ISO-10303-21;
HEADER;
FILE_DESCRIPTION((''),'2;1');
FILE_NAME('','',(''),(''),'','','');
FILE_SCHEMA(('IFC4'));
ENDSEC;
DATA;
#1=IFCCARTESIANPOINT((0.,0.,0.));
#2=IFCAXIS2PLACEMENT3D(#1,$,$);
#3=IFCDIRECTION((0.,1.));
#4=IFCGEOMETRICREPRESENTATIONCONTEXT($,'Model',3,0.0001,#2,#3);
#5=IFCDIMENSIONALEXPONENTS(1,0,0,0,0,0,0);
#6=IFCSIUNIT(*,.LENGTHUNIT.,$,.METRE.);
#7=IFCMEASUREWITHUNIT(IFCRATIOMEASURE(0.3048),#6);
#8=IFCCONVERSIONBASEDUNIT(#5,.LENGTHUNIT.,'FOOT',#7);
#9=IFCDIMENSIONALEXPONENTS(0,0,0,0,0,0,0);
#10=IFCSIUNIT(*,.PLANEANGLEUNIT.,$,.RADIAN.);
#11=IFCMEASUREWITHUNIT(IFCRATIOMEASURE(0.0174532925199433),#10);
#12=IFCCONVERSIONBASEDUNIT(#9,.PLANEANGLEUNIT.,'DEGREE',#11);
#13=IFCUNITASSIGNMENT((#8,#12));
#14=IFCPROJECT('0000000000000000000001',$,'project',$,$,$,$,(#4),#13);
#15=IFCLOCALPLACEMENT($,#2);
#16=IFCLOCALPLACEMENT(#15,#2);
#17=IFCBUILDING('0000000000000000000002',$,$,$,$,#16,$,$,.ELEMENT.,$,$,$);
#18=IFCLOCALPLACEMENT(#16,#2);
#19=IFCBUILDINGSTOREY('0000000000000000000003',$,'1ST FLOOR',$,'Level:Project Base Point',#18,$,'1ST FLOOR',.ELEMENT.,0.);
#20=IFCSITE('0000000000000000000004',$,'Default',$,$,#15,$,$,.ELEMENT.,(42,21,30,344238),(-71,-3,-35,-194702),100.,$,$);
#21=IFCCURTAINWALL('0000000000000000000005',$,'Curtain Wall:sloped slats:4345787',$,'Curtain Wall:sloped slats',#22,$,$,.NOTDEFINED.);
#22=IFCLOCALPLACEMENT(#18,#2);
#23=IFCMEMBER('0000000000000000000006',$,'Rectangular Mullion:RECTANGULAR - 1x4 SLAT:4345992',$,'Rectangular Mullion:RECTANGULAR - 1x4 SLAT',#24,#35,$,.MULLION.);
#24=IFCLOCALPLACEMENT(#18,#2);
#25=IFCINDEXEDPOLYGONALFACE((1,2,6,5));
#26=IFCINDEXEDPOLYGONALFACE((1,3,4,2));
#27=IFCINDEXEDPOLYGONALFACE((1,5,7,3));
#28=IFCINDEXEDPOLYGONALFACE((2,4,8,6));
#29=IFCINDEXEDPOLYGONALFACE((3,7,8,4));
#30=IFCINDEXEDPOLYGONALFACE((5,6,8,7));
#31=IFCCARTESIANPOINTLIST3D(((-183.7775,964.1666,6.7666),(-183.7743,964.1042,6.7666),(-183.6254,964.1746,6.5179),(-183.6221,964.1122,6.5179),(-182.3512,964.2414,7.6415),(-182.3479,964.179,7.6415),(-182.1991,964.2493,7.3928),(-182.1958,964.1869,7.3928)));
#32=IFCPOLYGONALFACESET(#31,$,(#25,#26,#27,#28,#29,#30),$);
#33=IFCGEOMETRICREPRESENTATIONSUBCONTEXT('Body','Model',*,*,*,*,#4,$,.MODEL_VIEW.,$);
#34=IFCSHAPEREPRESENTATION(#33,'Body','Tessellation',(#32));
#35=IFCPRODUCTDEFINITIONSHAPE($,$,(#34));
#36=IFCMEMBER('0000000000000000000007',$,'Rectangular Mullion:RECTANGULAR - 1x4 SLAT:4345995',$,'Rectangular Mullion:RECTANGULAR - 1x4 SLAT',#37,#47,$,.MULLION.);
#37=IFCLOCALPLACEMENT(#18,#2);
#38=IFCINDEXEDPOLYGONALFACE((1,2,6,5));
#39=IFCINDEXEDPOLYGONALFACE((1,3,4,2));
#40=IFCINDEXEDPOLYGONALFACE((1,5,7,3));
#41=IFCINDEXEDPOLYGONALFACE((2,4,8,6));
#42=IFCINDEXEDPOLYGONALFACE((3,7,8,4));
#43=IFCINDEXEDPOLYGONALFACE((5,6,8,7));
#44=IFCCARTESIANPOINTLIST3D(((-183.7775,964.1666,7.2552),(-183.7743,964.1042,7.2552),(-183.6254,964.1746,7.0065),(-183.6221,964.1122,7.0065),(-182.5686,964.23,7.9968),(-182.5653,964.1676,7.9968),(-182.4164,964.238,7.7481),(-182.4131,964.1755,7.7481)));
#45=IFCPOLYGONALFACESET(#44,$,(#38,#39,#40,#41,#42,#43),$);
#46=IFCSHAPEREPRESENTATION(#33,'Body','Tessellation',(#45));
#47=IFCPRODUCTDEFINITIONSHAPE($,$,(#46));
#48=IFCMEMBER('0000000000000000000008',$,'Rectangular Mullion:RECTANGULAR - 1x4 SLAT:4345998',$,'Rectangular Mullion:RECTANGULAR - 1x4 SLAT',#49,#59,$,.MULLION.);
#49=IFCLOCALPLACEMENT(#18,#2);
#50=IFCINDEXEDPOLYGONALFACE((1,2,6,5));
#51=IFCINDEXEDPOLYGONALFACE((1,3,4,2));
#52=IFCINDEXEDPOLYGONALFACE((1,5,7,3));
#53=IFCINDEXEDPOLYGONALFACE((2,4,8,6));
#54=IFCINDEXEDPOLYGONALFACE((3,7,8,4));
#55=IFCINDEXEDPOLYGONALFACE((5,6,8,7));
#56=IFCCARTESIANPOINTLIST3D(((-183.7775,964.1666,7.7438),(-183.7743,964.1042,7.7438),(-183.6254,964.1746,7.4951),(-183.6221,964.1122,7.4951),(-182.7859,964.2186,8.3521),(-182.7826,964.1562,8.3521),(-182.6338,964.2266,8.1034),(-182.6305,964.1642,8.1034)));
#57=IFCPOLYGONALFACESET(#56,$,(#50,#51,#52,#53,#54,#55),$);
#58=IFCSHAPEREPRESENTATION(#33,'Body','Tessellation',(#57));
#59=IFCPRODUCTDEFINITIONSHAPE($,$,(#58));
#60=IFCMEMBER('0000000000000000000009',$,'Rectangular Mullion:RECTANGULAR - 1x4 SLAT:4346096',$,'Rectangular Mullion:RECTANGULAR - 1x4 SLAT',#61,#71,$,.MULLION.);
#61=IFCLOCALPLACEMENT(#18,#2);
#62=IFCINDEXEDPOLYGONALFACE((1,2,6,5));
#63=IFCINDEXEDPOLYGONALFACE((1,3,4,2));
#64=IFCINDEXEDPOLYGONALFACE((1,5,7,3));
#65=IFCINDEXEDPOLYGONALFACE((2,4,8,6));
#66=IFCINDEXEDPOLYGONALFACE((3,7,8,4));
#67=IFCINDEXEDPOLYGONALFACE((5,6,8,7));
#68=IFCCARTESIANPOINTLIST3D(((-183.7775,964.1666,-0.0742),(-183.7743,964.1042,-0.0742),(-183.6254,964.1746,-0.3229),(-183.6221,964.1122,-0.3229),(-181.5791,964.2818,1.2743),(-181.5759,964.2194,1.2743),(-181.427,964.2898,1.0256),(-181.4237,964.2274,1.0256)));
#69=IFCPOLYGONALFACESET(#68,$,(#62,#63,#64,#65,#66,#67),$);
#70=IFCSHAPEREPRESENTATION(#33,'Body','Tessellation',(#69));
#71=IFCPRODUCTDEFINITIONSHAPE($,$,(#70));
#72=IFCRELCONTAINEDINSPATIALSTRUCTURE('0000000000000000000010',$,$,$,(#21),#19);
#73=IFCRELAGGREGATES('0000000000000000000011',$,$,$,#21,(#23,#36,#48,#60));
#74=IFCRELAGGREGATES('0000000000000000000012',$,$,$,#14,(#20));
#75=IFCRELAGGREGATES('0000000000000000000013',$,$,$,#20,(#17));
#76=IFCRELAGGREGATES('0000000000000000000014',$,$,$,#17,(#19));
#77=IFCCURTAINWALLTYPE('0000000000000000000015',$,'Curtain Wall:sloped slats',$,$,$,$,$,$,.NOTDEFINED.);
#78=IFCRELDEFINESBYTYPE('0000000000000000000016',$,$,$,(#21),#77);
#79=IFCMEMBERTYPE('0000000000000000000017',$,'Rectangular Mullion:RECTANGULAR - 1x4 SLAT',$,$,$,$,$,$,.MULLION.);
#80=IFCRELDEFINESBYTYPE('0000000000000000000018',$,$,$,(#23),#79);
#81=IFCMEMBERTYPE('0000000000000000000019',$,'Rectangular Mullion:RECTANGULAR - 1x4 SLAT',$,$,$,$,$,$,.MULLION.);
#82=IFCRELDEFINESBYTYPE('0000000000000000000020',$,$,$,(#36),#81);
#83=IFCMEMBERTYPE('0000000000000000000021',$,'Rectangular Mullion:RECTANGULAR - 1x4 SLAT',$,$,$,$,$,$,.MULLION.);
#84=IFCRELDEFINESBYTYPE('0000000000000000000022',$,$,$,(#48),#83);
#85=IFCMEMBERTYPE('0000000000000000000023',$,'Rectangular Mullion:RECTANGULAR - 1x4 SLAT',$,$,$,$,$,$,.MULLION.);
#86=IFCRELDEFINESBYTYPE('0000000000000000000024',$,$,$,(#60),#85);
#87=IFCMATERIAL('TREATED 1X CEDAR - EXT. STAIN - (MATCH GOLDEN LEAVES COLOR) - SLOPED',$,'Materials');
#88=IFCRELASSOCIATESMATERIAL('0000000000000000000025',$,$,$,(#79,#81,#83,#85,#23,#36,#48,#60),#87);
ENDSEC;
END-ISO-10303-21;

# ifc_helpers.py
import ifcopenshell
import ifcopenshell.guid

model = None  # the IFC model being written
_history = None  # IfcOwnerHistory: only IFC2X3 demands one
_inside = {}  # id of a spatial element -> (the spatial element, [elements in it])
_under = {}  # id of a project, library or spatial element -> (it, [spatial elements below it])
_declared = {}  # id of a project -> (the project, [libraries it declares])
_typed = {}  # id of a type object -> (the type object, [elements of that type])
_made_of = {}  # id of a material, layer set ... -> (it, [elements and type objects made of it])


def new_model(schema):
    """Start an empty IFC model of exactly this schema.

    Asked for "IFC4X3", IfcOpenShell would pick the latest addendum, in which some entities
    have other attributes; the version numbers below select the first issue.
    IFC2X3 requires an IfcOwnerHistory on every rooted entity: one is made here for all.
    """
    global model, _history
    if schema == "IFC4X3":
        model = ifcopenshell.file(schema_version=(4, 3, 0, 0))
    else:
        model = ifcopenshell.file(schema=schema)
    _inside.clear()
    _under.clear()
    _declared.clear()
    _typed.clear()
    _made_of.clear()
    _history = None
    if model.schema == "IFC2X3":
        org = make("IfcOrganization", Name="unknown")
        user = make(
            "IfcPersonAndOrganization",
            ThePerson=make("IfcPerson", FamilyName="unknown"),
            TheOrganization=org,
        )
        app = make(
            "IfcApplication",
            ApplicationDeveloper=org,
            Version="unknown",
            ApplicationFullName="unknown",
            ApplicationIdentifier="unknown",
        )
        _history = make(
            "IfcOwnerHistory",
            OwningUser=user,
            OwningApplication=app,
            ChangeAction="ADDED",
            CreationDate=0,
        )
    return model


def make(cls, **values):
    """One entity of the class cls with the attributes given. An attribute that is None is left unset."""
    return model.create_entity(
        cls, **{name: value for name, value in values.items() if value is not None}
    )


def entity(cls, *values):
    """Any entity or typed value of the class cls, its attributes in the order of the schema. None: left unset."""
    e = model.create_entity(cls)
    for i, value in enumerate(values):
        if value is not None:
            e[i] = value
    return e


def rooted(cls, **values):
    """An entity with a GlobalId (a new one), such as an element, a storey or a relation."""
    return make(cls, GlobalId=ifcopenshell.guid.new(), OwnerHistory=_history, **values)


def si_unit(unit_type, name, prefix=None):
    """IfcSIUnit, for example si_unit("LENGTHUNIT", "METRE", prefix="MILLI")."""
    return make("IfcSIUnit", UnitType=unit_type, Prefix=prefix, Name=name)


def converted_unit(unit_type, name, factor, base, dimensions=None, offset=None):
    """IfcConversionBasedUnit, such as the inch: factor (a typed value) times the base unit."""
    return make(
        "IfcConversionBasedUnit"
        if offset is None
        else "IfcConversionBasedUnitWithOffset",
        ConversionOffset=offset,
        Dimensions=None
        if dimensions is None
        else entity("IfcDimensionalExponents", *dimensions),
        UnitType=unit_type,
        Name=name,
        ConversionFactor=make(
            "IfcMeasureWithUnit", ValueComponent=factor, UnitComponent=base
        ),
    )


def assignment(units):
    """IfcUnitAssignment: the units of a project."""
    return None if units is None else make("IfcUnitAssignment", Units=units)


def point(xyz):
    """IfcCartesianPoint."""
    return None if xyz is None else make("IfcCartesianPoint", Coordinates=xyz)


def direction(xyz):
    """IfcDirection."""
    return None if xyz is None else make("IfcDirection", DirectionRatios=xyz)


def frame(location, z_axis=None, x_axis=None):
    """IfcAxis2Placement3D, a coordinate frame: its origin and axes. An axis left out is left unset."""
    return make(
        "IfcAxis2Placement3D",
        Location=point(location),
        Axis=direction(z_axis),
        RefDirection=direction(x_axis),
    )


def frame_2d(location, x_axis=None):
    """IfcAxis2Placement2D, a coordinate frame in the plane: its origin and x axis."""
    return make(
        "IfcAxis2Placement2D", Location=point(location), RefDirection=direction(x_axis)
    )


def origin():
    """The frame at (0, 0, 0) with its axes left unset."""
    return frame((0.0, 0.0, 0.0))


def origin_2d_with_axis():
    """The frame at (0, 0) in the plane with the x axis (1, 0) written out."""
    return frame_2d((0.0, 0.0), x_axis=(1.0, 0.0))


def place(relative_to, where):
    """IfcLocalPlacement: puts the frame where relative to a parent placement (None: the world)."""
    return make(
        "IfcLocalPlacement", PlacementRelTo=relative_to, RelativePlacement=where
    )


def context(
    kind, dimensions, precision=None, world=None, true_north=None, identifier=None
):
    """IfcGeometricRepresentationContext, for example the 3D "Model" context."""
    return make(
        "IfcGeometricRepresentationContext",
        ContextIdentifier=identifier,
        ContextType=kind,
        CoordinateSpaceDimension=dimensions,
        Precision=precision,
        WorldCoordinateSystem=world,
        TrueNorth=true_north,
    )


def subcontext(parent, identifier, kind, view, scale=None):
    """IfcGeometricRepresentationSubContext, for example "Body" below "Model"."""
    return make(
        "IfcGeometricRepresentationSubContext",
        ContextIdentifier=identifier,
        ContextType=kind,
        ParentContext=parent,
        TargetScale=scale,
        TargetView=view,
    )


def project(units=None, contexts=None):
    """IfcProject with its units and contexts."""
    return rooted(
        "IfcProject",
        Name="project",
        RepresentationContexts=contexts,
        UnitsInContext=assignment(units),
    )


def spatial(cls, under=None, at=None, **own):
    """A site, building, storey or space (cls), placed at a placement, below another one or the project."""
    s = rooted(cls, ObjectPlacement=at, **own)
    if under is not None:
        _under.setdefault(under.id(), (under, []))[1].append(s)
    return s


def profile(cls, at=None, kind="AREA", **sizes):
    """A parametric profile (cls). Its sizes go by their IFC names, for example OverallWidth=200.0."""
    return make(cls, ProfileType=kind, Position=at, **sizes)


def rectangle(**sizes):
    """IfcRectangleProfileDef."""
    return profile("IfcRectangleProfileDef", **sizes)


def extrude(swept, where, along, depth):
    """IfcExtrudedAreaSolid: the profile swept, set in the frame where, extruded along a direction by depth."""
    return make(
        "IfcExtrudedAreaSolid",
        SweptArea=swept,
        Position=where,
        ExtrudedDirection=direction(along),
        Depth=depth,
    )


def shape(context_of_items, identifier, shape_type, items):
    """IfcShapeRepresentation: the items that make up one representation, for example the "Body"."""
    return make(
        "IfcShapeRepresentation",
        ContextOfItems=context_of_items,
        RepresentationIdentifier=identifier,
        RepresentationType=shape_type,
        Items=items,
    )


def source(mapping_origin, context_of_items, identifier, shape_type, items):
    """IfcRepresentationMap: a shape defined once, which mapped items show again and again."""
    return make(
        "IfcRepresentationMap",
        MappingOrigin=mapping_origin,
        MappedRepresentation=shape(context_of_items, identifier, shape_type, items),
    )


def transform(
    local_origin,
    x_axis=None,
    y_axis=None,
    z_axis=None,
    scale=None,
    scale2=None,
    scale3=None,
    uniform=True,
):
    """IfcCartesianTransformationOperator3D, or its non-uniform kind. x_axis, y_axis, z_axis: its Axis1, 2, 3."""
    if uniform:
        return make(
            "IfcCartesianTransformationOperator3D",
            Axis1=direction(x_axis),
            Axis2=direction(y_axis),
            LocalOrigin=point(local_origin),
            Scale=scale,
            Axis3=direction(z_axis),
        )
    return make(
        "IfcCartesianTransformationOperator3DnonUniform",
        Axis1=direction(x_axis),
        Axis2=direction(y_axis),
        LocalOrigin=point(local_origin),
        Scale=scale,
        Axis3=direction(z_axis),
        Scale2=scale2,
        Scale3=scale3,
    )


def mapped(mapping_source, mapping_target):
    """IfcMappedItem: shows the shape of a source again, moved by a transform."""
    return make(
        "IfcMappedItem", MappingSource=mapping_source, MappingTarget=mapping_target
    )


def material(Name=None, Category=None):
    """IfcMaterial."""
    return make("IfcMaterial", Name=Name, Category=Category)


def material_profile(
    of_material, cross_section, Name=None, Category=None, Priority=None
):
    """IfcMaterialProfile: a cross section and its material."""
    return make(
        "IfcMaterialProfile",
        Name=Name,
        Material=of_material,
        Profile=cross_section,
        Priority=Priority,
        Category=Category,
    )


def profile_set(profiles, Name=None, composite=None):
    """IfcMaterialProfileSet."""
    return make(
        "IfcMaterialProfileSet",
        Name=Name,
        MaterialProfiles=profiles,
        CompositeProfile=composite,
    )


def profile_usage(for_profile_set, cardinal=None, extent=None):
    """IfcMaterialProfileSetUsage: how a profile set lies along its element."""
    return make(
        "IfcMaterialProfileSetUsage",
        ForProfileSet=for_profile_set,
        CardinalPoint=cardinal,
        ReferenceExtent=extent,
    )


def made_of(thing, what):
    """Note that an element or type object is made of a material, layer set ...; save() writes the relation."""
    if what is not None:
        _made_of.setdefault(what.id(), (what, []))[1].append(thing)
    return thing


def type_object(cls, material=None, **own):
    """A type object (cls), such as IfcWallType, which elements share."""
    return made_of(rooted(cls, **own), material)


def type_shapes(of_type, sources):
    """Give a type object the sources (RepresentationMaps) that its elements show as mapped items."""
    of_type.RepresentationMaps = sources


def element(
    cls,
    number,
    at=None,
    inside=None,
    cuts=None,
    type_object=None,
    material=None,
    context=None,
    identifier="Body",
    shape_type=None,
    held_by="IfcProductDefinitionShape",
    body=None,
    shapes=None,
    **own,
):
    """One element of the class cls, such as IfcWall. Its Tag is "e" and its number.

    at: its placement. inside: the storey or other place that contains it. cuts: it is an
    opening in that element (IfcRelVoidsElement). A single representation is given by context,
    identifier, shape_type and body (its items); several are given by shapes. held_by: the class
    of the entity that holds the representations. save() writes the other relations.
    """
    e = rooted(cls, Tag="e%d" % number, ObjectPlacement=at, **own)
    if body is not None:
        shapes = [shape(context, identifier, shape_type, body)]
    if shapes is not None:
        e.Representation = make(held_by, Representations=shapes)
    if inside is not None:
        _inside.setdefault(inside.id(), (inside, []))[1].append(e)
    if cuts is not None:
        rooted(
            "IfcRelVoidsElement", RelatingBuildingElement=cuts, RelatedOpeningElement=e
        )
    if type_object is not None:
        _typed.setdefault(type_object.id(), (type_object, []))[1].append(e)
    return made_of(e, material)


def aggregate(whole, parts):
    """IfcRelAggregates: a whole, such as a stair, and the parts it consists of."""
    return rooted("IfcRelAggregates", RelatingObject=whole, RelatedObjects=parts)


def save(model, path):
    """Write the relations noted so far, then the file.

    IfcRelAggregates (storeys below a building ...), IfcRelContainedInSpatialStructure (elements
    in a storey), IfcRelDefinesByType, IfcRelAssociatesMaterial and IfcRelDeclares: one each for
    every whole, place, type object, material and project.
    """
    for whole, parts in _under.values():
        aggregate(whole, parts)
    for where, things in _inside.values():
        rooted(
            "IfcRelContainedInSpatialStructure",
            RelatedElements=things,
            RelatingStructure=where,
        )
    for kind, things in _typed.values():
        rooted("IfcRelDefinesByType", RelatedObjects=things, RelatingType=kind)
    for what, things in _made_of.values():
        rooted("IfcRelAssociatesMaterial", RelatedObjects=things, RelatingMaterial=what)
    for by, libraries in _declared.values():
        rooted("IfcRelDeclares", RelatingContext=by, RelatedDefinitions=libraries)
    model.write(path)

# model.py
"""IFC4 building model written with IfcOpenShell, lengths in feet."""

from ifc_helpers import new_model, entity, si_unit, converted_unit, direction, frame, frame_2d, origin, origin_2d_with_axis, place, context, subcontext, project, spatial, rectangle, extrude, source, transform, mapped, material, material_profile, profile_set, profile_usage, type_object, type_shapes, element, aggregate, save


model = new_model("IFC4")

# Units and contexts
model_context = context("Model", 3, precision=0.0001, world=origin(), true_north=direction((0.0, 1.0)))
body_context = subcontext(model_context, "Body", "Model", "MODEL_VIEW")
ifc_project = project(units=[converted_unit("LENGTHUNIT", "FOOT", entity("IfcRatioMeasure", 0.3048), si_unit("LENGTHUNIT", "METRE"), dimensions=[1, 0, 0, 0, 0, 0, 0]), converted_unit("PLANEANGLEUNIT", "DEGREE", entity("IfcRatioMeasure", 0.0174532925199433), si_unit("PLANEANGLEUNIT", "RADIAN"), dimensions=[0, 0, 0, 0, 0, 0, 0])], contexts=[model_context])

# Site, building, storey
site_placement = place(None, origin())
site = spatial("IfcSite", under=ifc_project, at=site_placement, Name="Default", CompositionType="ELEMENT", RefLatitude=(42, 21, 30, 344238), RefLongitude=(-71, -3, -35, -194702), RefElevation=100.0)
building_placement = place(site_placement, origin())
building = spatial("IfcBuilding", under=site, at=building_placement, CompositionType="ELEMENT")
storey_placement = place(building_placement, origin())
storey = spatial("IfcBuildingStorey", under=building, at=storey_placement, Name="1ST FLOOR", ObjectType="Level:Project Base Point", LongName="1ST FLOOR", CompositionType="ELEMENT", Elevation=0.0)

# Curtain wall
curtain_wall_type_1 = type_object("IfcCurtainWallType", Name="Curtain Wall:sloped slats", PredefinedType="NOTDEFINED")
curtain_wall_1_placement = place(storey_placement, origin())
curtain_wall_1 = element("IfcCurtainWall", 1, at=curtain_wall_1_placement, inside=storey, type_object=curtain_wall_type_1, Name="Curtain Wall:sloped slats:4345787", ObjectType="Curtain Wall:sloped slats", PredefinedType="NOTDEFINED")
ifc_material_1 = material(Name="TREATED 1X CEDAR - EXT. STAIN - (MATCH GOLDEN LEAVES COLOR) - SLOPED", Category="Materials")
ifc_material_profile_1 = material_profile(ifc_material_1, rectangle(XDim=0.0625, YDim=0.2917, at=frame_2d((0.0, 0.0), x_axis=(1.0, 0.0))), Name="RECTANGULAR - 1x4 SLAT")
ifc_profile_set_1 = profile_set([ifc_material_profile_1], Name="RECTANGULAR - 1x4 SLAT")

# Members
ifc_profile_usage_1 = profile_usage(ifc_profile_set_1)
member_type_1 = type_object("IfcMemberType", Name="Rectangular Mullion:RECTANGULAR - 1x4 SLAT", PredefinedType="MULLION", material=ifc_profile_set_1)
shared_shape_1 = source(origin(), body_context, "Body", "SweptSolid", [
    extrude(rectangle(XDim=0.0625, YDim=0.2917, at=frame_2d((0.0, 0.0), x_axis=(1.0, 0.0))), frame((0.0, 0.0, -1.6749), z_axis=(0.0, 0.0, 1.0), x_axis=(0.0, -1.0, 0.0)), (0.0, 0.0, 1.0), 1.6749),
])
type_shapes(member_type_1, [shared_shape_1])
member_1_placement = place(storey_placement, frame((-183.6998, 964.1394, 6.6422), z_axis=(-0.851559, -0.044628, -0.522356), x_axis=(-0.52164, -0.027338, 0.852727)))
member_1 = element("IfcMember", 2, at=member_1_placement, type_object=member_type_1, material=ifc_profile_usage_1, Name="Rectangular Mullion:RECTANGULAR - 1x4 SLAT:4345992", ObjectType="Rectangular Mullion:RECTANGULAR - 1x4 SLAT", PredefinedType="MULLION", context=body_context, shape_type="MappedRepresentation", body=[
    mapped(shared_shape_1, transform((0.0, 0.0, 0.0), scale=1.0)),
])
ifc_profile_usage_2 = profile_usage(ifc_profile_set_1)
member_type_2 = type_object("IfcMemberType", Name="Rectangular Mullion:RECTANGULAR - 1x4 SLAT", PredefinedType="MULLION", material=ifc_profile_set_1)
shared_shape_2 = source(origin(), body_context, "Body", "SweptSolid", [
    extrude(rectangle(XDim=0.0625, YDim=0.2917, at=frame_2d((0.0, 0.0), x_axis=(1.0, 0.0))), frame((0.0, 0.0, -1.4197), z_axis=(0.0, 0.0, 1.0), x_axis=(0.0, -1.0, 0.0)), (0.0, 0.0, 1.0), 1.4197),
])
type_shapes(member_type_2, [shared_shape_2])
member_2_placement = place(storey_placement, frame((-183.6998, 964.1394, 7.1309), z_axis=(-0.851559, -0.044628, -0.522356), x_axis=(-0.52164, -0.027338, 0.852727)))
member_2 = element("IfcMember", 3, at=member_2_placement, type_object=member_type_2, material=ifc_profile_usage_2, Name="Rectangular Mullion:RECTANGULAR - 1x4 SLAT:4345995", ObjectType="Rectangular Mullion:RECTANGULAR - 1x4 SLAT", PredefinedType="MULLION", context=body_context, shape_type="MappedRepresentation", body=[
    mapped(shared_shape_2, transform((0.0, 0.0, 0.0), scale=1.0)),
])
ifc_profile_usage_3 = profile_usage(ifc_profile_set_1)
member_type_3 = type_object("IfcMemberType", Name="Rectangular Mullion:RECTANGULAR - 1x4 SLAT", PredefinedType="MULLION", material=ifc_profile_set_1)
shared_shape_3 = source(origin(), body_context, "Body", "SweptSolid", [
    extrude(rectangle(XDim=0.0625, YDim=0.2917, at=origin_2d_with_axis()), frame((0.0, 0.0, -1.1645), z_axis=(0.0, 0.0, 1.0), x_axis=(0.0, -1.0, 0.0)), (0.0, 0.0, 1.0), 1.1645),
])
type_shapes(member_type_3, [shared_shape_3])
member_3_placement = place(storey_placement, frame((-183.6998, 964.1394, 7.6195), z_axis=(-0.851559, -0.044628, -0.522356), x_axis=(-0.52164, -0.027338, 0.852727)))
member_3 = element("IfcMember", 4, at=member_3_placement, type_object=member_type_3, material=ifc_profile_usage_3, Name="Rectangular Mullion:RECTANGULAR - 1x4 SLAT:4345998", ObjectType="Rectangular Mullion:RECTANGULAR - 1x4 SLAT", PredefinedType="MULLION", context=body_context, shape_type="MappedRepresentation", body=[
    mapped(shared_shape_3, transform((0.0, 0.0, 0.0), scale=1.0)),
])
ifc_profile_usage_4 = profile_usage(ifc_profile_set_1)
member_type_4 = type_object("IfcMemberType", Name="Rectangular Mullion:RECTANGULAR - 1x4 SLAT", PredefinedType="MULLION", material=ifc_profile_set_1)
shared_shape_4 = source(origin(), body_context, "Body", "SweptSolid", [
    extrude(rectangle(XDim=0.0625, YDim=0.2917, at=frame_2d((0.0, 0.0), x_axis=(1.0, 0.0))), frame((0.0, 0.0, -2.5816), z_axis=(0.0, 0.0, 1.0), x_axis=(0.0, -1.0, 0.0)), (0.0, 0.0, 1.0), 2.5816),
])
type_shapes(member_type_4, [shared_shape_4])
member_4_placement = place(storey_placement, frame((-183.6998, 964.1394, -0.1986), z_axis=(-0.851559, -0.044628, -0.522356), x_axis=(-0.52164, -0.027338, 0.852727)))
member_4 = element("IfcMember", 5, at=member_4_placement, type_object=member_type_4, material=ifc_profile_usage_4, Name="Rectangular Mullion:RECTANGULAR - 1x4 SLAT:4346096", ObjectType="Rectangular Mullion:RECTANGULAR - 1x4 SLAT", PredefinedType="MULLION", context=body_context, shape_type="MappedRepresentation", body=[
    mapped(shared_shape_4, transform((0.0, 0.0, 0.0), scale=1.0)),
])
aggregate(curtain_wall_1, [member_1, member_2, member_3, member_4])

save(model, "model.ifc")
